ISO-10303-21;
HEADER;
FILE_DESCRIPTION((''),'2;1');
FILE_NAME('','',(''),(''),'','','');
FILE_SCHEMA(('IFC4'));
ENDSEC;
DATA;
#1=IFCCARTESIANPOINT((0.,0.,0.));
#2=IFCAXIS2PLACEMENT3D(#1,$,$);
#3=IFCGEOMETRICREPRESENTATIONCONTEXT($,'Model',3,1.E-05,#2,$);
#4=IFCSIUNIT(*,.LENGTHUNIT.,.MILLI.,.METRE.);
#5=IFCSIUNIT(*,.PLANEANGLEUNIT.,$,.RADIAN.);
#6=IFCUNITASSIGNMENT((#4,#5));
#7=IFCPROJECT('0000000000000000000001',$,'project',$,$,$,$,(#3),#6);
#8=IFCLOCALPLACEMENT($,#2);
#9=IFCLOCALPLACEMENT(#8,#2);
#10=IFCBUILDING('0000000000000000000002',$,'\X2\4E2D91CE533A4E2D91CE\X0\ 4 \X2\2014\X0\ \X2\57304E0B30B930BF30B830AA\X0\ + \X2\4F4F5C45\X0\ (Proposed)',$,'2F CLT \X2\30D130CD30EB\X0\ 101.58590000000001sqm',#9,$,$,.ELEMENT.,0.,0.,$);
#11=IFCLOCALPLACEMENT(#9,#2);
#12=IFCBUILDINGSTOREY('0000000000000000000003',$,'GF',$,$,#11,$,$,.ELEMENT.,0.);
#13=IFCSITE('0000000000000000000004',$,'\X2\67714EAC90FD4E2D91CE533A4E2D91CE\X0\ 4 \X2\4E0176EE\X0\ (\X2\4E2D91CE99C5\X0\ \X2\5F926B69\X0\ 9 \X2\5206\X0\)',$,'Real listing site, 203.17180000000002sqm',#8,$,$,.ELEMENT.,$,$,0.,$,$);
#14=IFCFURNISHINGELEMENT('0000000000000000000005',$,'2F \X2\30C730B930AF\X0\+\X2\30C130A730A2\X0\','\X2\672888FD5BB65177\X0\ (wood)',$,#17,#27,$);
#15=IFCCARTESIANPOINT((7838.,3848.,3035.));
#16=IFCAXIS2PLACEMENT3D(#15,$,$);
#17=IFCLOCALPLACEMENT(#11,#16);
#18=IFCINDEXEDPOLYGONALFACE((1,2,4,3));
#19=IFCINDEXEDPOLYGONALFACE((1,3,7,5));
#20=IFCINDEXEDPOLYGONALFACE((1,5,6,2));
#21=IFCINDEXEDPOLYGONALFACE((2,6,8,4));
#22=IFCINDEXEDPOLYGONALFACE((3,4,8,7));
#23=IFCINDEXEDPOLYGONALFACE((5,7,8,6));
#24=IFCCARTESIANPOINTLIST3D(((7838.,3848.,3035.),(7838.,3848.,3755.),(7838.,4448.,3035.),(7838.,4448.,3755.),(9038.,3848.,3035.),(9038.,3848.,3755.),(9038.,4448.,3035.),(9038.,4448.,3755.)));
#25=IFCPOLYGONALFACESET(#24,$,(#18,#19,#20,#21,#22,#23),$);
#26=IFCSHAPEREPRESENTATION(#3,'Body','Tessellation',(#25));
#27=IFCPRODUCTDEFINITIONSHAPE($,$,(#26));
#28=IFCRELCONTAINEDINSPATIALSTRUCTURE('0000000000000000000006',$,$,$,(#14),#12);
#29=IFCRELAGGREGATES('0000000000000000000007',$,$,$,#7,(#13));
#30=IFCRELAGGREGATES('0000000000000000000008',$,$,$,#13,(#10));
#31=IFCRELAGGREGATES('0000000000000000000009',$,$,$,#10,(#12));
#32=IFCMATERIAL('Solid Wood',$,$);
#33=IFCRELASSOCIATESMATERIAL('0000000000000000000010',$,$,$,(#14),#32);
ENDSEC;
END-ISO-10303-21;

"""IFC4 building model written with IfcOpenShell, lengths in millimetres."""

from ifc_helpers import new_model, si_unit, frame, frame_2d, origin, place, context, project, spatial, rectangle, extrude, material, element, save


model = new_model("IFC4")

# Units and contexts
model_context = context("Model", 3, precision=1e-05, world=origin())
ifc_project = project(units=[si_unit("LENGTHUNIT", "METRE", prefix="MILLI"), si_unit("PLANEANGLEUNIT", "RADIAN")], contexts=[model_context])

# Site, building, storey
site_placement = place(None, origin())
site = spatial("IfcSite", under=ifc_project, at=site_placement, Name="東京都中野区中野 4 丁目 (中野駅 徒歩 9 分)", ObjectType="Real listing site, 203.17180000000002sqm", CompositionType="ELEMENT", RefElevation=0.0)
building_placement = place(site_placement, origin())
building = spatial("IfcBuilding", under=site, at=building_placement, Name="中野区中野 4 — 地下スタジオ + 住居 (Proposed)", ObjectType="2F CLT パネル 101.58590000000001sqm", CompositionType="ELEMENT", ElevationOfRefHeight=0.0, ElevationOfTerrain=0.0)
storey_placement = place(building_placement, origin())
storey = spatial("IfcBuildingStorey", under=building, at=storey_placement, Name="GF", CompositionType="ELEMENT", Elevation=0.0)

# Shared definitions
ifc_material_1 = material(Name="Solid Wood")

# Furnishing element
furnishing_1_placement = place(storey_placement, frame((7838.0, 3848.0, 3035.0)))
element("IfcFurnishingElement", 1, at=furnishing_1_placement, inside=storey, material=ifc_material_1, Name="2F デスク+チェア", Description="木製家具 (wood)", context=model_context, shape_type="SweptSolid", body=[
    extrude(rectangle(XDim=1200.0, YDim=600.0, at=frame_2d((600.0, 300.0))), frame((7838.0, 3848.0, 3035.0)), (0.0, 0.0, 1.0), 720.0),
])

save(model, "model.ifc")
